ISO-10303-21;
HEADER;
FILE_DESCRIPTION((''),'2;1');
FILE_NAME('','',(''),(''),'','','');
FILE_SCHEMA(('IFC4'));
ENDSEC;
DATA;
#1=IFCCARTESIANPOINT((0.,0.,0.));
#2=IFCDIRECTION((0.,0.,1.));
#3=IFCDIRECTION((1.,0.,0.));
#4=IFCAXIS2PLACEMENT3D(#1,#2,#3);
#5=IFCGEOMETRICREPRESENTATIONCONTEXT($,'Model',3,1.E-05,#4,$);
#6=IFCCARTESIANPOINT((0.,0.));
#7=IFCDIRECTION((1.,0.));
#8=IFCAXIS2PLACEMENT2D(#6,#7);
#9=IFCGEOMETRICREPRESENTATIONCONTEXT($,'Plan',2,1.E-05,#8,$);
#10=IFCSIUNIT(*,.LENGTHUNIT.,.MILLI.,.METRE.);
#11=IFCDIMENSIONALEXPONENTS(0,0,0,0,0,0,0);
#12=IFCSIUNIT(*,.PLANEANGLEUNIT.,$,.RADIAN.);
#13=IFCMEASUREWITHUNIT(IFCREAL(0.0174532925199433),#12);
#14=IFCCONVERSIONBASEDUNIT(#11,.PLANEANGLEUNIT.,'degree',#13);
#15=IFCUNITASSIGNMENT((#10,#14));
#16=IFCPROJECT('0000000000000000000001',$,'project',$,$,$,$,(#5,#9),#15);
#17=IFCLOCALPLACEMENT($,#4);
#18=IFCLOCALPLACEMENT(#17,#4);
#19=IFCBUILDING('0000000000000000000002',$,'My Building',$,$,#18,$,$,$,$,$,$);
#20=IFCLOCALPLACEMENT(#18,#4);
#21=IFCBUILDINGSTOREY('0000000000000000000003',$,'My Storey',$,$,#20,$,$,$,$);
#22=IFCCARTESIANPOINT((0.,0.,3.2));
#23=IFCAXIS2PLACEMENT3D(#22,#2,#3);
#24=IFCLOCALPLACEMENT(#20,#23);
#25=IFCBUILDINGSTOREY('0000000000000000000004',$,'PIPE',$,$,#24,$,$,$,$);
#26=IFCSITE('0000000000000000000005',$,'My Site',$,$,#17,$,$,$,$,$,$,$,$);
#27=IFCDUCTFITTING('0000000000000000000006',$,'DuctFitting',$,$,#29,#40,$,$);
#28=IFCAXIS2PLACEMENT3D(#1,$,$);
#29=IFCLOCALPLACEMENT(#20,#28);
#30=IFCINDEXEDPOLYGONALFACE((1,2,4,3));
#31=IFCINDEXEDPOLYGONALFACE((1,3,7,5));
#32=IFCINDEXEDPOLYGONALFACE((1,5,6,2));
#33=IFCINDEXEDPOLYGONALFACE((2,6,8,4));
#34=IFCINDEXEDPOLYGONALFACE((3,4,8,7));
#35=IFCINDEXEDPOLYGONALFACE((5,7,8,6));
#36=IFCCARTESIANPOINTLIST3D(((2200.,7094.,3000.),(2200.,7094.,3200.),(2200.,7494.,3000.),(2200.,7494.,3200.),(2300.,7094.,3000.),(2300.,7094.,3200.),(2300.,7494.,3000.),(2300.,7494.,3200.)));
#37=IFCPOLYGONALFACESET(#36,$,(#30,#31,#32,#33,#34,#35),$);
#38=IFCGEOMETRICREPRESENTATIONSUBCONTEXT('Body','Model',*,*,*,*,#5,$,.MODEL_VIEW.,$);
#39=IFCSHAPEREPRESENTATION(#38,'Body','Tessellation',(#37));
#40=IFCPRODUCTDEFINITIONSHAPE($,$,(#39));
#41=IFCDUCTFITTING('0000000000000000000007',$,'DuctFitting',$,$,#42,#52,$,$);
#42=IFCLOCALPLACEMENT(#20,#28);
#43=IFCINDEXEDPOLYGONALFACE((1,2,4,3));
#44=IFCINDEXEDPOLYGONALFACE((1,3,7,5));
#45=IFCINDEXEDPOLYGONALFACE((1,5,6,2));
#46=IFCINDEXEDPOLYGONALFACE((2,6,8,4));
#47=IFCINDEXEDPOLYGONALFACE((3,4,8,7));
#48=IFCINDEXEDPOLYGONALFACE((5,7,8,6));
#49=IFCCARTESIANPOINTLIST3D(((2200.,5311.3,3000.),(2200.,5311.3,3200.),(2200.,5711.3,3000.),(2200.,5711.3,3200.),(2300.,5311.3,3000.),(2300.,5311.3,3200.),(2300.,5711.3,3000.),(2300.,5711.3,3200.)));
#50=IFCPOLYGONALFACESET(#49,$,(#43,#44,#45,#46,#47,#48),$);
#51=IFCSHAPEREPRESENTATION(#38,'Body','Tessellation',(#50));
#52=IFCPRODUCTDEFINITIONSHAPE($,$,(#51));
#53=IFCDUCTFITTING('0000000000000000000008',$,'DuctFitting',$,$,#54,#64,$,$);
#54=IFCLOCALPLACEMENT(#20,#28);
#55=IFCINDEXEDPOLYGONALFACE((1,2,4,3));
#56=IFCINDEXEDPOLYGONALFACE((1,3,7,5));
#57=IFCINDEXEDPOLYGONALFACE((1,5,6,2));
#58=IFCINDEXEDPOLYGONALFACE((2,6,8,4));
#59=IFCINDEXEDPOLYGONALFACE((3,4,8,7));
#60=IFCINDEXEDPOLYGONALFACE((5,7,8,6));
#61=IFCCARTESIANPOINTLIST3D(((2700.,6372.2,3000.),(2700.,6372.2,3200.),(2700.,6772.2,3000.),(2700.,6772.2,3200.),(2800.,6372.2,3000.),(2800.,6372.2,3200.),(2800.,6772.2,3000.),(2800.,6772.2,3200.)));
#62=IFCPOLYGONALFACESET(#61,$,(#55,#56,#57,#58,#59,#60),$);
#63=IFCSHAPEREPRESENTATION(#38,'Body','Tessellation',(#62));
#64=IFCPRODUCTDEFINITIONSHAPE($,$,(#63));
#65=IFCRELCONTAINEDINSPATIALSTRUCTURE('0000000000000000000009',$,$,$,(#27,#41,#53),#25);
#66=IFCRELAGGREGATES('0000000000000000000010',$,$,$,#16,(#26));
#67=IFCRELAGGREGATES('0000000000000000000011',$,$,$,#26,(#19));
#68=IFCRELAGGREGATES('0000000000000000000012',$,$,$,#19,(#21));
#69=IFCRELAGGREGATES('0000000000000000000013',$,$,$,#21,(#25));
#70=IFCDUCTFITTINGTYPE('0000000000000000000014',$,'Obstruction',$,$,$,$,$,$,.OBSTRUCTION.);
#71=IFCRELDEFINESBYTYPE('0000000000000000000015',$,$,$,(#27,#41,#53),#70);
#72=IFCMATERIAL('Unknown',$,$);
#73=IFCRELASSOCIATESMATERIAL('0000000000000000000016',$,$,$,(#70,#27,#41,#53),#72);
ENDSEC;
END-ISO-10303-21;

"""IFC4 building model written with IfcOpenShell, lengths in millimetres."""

from ifc_helpers import new_model, entity, si_unit, converted_unit, frame, origin_with_axes, origin_2d_with_axis, place, context, subcontext, project, spatial, rectangle, extrude, material, material_profile, profile_set, profile_usage, type_object, element, save


model = new_model("IFC4")

# Units and contexts
model_context = context("Model", 3, precision=1e-05, world=origin_with_axes())
plan_context = context("Plan", 2, precision=1e-05, world=origin_2d_with_axis())
body_context = subcontext(model_context, "Body", "Model", "MODEL_VIEW")
ifc_project = project(units=[si_unit("LENGTHUNIT", "METRE", prefix="MILLI"), converted_unit("PLANEANGLEUNIT", "degree", entity("IfcReal", 0.0174532925199433), si_unit("PLANEANGLEUNIT", "RADIAN"), dimensions=[0, 0, 0, 0, 0, 0, 0])], contexts=[model_context, plan_context])

# Site, building, storeys
site_placement = place(None, origin_with_axes())
site = spatial("IfcSite", under=ifc_project, at=site_placement, Name="My Site")
building_placement = place(site_placement, origin_with_axes())
building = spatial("IfcBuilding", under=site, at=building_placement, Name="My Building")
storey_1_placement = place(building_placement, origin_with_axes())
storey_1 = spatial("IfcBuildingStorey", under=building, at=storey_1_placement, Name="My Storey")
storey_2_placement = place(storey_1_placement, frame((0.0, 0.0, 3.2), z_axis=(0.0, 0.0, 1.0), x_axis=(1.0, 0.0, 0.0)))
storey_2 = spatial("IfcBuildingStorey", under=storey_1, at=storey_2_placement, Name="PIPE")

# Shared definitions
ifc_material = material(Name="Unknown")

# Duct fittings
ifc_material_profile_1 = material_profile(ifc_material, rectangle(XDim=400.0, YDim=200.0))
ifc_profile_set_1 = profile_set([ifc_material_profile_1])
ifc_profile_usage_1 = profile_usage(ifc_profile_set_1, cardinal=10)
duct_fitting_type = type_object("IfcDuctFittingType", Name="Obstruction", PredefinedType="OBSTRUCTION", material=ifc_profile_set_1)
duct_fitting_1_placement = place(storey_2_placement, frame((2300.0, 7294.0, 3096.8), z_axis=(-1.0, 0.0, 0.0), x_axis=(0.0, -1.0, 0.0)))
element("IfcDuctFitting", 1, at=duct_fitting_1_placement, inside=storey_2, type_object=duct_fitting_type, material=ifc_profile_usage_1, Name="DuctFitting", context=body_context, shape_type="SweptSolid", body=[
    extrude(rectangle(XDim=400.0, YDim=200.0), origin_with_axes(), (0.0, 0.0, 1.0), 100.0),
])
ifc_profile_usage_2 = profile_usage(ifc_profile_set_1, cardinal=10)
duct_fitting_2_placement = place(storey_2_placement, frame((2300.0, 5511.3, 3096.8), z_axis=(-1.0, 0.0, 0.0), x_axis=(0.0, -1.0, 0.0)))
element("IfcDuctFitting", 2, at=duct_fitting_2_placement, inside=storey_2, type_object=duct_fitting_type, material=ifc_profile_usage_2, Name="DuctFitting", context=body_context, shape_type="SweptSolid", body=[
    extrude(rectangle(XDim=400.0, YDim=200.0), origin_with_axes(), (0.0, 0.0, 1.0), 100.0),
])
ifc_profile_usage_3 = profile_usage(ifc_profile_set_1, cardinal=10)
duct_fitting_3_placement = place(storey_2_placement, frame((2700.0, 6572.2, 3096.8), z_axis=(1.0, 0.0, 0.0), x_axis=(0.0, 1.0, 0.0)))
element("IfcDuctFitting", 3, at=duct_fitting_3_placement, inside=storey_2, type_object=duct_fitting_type, material=ifc_profile_usage_3, Name="DuctFitting", context=body_context, shape_type="SweptSolid", body=[
    extrude(rectangle(XDim=400.0, YDim=200.0), origin_with_axes(), (0.0, 0.0, 1.0), 100.0),
])

save(model, "model.ifc")
